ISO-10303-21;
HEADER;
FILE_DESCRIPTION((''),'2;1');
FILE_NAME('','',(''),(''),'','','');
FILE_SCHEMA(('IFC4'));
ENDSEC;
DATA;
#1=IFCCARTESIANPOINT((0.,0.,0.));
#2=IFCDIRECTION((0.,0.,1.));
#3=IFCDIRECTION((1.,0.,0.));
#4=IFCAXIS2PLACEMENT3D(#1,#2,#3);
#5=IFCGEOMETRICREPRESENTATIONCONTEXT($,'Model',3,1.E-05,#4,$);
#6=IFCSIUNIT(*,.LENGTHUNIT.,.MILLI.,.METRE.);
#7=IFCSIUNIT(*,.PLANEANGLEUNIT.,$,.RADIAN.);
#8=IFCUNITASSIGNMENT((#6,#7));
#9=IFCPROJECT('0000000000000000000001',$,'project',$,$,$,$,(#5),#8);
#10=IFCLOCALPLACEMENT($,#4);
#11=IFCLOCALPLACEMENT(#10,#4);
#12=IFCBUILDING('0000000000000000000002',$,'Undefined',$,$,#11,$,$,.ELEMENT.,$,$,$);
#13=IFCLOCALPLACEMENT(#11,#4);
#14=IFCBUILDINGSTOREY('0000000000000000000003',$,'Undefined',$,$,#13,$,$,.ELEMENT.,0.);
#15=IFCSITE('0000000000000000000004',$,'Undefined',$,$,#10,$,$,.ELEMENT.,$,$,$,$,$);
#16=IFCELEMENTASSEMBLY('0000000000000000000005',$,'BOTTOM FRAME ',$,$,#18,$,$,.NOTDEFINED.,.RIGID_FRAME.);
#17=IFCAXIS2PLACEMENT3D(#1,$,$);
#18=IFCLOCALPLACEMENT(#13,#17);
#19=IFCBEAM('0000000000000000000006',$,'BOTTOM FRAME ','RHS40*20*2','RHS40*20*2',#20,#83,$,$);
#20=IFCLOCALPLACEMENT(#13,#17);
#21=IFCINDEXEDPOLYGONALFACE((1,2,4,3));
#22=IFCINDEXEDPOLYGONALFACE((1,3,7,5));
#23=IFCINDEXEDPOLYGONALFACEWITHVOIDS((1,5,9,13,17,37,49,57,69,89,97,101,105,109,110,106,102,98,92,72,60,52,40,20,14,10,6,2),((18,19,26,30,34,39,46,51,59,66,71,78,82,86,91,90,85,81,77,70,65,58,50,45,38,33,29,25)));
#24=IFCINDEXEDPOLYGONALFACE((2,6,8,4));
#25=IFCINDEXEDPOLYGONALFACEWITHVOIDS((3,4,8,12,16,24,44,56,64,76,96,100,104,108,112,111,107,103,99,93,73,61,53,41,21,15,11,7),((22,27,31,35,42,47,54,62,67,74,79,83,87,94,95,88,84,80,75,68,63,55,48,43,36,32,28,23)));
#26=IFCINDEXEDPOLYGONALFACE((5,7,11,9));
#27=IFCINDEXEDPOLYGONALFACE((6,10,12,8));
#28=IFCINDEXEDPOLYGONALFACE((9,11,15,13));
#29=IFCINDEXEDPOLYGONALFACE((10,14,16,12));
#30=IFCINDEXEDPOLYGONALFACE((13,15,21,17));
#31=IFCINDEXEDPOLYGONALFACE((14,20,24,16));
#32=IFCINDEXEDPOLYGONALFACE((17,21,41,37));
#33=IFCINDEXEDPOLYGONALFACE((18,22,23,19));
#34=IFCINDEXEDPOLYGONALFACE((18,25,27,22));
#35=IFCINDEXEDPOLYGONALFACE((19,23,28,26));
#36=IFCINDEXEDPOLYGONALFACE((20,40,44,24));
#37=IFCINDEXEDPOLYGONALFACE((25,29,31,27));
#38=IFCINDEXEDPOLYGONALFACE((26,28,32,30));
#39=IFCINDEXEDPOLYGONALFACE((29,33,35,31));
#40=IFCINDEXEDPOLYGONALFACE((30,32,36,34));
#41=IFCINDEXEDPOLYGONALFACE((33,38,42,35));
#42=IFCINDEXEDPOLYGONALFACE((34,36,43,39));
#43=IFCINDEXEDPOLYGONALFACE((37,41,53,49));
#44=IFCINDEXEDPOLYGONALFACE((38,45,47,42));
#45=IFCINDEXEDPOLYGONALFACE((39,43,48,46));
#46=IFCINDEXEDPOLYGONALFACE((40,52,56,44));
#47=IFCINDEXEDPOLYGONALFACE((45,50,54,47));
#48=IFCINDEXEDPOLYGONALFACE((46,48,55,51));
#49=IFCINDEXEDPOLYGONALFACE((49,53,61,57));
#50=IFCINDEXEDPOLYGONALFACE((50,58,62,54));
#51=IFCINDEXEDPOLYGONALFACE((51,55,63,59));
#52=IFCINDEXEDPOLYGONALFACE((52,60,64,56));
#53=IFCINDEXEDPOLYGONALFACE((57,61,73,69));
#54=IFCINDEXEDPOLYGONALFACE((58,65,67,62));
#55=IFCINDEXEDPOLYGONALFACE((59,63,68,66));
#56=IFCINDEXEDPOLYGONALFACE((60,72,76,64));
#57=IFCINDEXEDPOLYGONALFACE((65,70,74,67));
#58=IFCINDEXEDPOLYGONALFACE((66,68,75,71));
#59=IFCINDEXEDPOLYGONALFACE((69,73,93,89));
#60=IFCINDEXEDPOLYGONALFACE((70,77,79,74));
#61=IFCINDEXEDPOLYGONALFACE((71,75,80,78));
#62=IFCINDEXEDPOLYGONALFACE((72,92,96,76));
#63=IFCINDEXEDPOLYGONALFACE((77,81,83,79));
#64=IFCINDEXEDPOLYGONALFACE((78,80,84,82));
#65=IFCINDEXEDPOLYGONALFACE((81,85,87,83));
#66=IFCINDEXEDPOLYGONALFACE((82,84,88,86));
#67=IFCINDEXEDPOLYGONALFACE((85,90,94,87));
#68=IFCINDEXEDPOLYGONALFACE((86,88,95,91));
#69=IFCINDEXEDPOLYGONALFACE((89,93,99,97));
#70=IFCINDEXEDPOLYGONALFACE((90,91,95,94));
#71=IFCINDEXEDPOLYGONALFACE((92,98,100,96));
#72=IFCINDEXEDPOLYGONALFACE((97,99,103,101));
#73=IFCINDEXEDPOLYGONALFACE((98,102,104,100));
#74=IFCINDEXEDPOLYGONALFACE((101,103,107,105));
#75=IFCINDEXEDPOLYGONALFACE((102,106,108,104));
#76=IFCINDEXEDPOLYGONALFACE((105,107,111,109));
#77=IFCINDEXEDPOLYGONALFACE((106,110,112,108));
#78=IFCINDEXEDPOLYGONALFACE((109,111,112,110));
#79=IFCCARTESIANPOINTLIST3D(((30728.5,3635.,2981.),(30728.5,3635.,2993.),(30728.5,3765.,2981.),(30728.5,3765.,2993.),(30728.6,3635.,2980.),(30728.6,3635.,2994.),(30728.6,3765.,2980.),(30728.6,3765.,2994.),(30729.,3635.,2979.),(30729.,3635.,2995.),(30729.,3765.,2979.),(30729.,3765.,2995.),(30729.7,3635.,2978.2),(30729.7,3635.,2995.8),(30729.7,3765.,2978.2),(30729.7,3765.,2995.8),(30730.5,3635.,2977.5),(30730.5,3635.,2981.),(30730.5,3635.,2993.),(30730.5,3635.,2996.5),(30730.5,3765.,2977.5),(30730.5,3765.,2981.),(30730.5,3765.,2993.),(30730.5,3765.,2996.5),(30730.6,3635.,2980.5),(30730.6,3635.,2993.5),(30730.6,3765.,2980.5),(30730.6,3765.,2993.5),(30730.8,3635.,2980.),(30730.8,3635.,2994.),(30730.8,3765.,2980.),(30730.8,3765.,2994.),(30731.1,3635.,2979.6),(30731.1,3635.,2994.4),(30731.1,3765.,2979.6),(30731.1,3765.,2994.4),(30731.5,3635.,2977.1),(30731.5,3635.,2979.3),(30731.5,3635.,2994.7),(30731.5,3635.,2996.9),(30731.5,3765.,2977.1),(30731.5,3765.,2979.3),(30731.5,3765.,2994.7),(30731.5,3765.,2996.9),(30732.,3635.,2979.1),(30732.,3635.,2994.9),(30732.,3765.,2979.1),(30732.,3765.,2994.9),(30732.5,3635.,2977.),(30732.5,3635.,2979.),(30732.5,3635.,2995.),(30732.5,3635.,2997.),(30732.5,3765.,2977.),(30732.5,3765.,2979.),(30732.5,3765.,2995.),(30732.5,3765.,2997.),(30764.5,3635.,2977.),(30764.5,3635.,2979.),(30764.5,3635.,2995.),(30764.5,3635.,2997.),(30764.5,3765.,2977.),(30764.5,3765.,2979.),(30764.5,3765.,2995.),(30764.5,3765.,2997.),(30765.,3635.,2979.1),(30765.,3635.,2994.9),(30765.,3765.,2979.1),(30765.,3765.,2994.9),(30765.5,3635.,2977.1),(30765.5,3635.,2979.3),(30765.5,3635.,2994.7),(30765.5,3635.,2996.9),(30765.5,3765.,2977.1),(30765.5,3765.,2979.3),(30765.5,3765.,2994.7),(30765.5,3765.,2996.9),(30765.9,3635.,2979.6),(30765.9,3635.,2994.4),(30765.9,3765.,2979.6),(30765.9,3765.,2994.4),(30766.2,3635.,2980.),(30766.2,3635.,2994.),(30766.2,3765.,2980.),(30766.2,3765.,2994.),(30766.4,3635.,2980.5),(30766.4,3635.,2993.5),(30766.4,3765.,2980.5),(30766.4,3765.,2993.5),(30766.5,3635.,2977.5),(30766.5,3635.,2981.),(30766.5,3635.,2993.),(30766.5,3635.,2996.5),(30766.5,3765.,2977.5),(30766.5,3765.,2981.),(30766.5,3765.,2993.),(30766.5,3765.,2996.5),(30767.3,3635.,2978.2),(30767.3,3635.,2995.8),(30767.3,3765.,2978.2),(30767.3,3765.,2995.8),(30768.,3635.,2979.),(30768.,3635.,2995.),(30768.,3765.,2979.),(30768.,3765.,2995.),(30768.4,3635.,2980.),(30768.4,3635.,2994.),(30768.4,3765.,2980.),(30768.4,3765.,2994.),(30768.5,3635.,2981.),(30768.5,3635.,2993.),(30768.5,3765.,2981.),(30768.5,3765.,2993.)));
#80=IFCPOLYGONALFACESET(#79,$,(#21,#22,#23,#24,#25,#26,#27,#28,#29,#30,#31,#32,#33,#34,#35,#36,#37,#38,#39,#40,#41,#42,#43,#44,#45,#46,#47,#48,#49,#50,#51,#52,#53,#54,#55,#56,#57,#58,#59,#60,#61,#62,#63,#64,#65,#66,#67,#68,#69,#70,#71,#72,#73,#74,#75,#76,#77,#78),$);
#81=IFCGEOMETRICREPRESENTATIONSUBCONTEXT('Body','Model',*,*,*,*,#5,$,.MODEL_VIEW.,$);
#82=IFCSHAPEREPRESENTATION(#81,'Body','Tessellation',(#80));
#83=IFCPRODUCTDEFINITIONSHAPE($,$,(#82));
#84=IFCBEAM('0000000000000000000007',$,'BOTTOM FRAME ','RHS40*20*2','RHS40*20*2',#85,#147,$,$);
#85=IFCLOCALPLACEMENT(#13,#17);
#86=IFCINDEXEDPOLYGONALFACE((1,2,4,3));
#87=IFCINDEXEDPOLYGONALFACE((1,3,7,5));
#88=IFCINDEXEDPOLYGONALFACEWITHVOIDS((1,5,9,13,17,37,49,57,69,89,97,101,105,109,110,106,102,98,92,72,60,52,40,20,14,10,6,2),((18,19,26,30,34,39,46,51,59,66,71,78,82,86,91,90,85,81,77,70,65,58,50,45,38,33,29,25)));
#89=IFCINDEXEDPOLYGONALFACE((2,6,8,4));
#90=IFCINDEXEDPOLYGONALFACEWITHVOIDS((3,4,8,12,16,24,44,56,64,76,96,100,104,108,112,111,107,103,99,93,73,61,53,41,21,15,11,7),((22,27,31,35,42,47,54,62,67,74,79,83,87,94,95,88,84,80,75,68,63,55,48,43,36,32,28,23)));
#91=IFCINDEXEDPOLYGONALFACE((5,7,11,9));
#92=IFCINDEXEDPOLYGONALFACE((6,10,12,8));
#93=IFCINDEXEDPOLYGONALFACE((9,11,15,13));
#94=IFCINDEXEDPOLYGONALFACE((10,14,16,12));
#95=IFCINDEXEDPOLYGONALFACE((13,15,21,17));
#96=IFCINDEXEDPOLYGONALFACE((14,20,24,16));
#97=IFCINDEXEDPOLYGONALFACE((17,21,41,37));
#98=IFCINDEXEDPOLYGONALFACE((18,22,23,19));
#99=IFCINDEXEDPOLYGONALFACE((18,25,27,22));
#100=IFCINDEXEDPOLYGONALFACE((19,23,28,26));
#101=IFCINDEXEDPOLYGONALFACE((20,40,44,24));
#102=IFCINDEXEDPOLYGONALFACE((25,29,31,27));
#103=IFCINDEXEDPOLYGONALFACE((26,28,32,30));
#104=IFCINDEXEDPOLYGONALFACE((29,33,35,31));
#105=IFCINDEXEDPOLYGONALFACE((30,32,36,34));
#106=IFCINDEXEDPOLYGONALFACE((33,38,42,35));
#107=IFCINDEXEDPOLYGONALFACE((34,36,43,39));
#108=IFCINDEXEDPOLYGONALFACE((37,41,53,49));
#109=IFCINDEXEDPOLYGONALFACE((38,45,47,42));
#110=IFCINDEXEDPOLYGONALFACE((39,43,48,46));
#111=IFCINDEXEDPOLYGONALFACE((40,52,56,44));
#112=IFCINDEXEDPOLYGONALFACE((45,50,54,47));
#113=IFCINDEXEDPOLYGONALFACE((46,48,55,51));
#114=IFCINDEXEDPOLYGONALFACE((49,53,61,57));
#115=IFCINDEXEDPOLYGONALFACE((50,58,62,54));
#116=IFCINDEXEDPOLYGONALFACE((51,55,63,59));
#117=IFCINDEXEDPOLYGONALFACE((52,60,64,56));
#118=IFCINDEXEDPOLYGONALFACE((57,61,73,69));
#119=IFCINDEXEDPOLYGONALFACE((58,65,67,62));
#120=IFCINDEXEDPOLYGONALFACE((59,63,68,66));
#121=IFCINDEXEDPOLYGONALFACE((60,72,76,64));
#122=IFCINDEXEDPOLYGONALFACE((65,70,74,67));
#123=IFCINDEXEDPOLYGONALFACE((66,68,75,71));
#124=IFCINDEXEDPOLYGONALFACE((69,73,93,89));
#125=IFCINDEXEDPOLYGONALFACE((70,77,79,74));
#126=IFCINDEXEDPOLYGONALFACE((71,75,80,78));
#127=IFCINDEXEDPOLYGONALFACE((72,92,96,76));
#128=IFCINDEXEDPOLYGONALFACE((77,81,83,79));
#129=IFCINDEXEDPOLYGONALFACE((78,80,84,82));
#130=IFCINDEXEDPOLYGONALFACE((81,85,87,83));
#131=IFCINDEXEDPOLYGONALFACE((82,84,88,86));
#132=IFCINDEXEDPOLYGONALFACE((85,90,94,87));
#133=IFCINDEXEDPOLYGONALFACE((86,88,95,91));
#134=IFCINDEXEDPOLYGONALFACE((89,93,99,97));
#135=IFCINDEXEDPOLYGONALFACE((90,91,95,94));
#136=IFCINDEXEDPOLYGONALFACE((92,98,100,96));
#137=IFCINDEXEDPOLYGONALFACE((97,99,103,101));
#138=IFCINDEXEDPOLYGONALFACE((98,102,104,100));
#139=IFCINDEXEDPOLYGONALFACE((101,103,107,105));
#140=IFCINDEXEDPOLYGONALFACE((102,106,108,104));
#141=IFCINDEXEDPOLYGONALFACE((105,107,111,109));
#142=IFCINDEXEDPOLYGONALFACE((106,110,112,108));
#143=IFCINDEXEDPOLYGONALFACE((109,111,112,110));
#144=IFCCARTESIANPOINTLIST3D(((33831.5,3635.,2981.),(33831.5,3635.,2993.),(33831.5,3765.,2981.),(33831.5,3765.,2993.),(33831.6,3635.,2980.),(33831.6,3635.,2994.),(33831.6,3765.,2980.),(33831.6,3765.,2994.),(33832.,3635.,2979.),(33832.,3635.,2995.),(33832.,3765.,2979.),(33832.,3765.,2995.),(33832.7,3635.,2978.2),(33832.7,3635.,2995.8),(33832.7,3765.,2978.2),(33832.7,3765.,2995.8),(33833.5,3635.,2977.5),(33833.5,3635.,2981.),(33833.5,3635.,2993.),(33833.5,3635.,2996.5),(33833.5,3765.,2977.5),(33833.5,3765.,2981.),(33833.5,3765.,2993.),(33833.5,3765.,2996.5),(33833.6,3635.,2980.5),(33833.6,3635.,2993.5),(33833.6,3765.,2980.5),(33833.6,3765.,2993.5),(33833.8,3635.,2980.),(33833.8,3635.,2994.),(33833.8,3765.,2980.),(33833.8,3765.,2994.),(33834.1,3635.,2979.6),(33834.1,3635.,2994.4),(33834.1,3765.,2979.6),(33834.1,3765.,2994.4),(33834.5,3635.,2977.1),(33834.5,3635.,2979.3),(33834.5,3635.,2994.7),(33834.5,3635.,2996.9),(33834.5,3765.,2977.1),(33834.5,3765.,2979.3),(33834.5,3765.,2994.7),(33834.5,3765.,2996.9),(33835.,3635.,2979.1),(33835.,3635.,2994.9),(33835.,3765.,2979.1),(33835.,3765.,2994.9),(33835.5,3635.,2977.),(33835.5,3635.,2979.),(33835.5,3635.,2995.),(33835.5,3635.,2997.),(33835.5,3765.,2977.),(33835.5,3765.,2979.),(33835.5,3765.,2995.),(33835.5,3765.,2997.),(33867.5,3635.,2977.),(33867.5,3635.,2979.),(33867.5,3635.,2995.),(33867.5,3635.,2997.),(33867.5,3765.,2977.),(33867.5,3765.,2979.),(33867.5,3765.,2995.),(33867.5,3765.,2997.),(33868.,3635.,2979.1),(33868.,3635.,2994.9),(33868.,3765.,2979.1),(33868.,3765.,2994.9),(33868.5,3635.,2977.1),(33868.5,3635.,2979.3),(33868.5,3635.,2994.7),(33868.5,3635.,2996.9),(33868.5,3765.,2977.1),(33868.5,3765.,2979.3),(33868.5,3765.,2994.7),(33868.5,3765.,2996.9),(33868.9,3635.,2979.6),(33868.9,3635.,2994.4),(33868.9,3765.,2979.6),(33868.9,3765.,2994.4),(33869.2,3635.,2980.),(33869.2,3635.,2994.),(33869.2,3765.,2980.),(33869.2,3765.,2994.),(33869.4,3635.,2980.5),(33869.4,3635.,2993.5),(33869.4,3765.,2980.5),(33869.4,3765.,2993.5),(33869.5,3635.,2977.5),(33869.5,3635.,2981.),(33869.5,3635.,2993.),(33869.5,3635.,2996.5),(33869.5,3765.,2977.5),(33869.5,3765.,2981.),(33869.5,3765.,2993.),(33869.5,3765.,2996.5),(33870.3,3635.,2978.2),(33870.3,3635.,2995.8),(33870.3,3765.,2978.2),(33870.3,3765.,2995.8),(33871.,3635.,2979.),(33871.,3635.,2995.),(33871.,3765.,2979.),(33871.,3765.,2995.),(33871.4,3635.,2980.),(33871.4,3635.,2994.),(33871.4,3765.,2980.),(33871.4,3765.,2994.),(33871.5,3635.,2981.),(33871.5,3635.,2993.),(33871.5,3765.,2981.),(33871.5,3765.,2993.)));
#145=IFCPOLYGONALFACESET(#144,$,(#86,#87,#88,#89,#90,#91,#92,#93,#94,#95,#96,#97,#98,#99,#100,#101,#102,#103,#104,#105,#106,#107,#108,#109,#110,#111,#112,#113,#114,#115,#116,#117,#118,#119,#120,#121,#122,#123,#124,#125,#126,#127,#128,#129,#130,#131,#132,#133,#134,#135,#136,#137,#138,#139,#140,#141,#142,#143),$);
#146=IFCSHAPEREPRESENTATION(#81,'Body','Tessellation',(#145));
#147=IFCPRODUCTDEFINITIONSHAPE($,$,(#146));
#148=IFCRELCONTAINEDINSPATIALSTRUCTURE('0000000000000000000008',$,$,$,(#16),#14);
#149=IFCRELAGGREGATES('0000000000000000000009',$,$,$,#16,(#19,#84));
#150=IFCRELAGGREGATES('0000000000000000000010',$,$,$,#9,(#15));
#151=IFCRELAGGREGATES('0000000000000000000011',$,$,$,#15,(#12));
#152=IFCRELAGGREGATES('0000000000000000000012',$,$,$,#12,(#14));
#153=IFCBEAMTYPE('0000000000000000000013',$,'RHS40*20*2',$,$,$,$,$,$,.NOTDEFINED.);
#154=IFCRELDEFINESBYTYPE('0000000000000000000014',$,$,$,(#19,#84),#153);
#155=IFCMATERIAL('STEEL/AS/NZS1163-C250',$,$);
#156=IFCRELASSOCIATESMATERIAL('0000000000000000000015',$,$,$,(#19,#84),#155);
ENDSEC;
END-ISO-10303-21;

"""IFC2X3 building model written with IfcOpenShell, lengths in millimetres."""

from ifc_helpers import new_model, si_unit, frame, origin_with_axes, origin_2d_with_axis, place, context, subcontext, project, spatial, hollow_rectangle, extrude, material, type_object, element, aggregate, save


model = new_model("IFC2X3")

# Units and contexts
model_context = context("Model", 3, precision=1e-05, world=origin_with_axes())
body_context = subcontext(model_context, "Body", "Model", "MODEL_VIEW")
ifc_project = project(units=[si_unit("LENGTHUNIT", "METRE", prefix="MILLI"), si_unit("PLANEANGLEUNIT", "RADIAN")], contexts=[model_context])

# Site, building, storey
site_placement = place(None, origin_with_axes())
site = spatial("IfcSite", under=ifc_project, at=site_placement, Name="Undefined", CompositionType="ELEMENT")
building_placement = place(site_placement, origin_with_axes())
building = spatial("IfcBuilding", under=site, at=building_placement, Name="Undefined", CompositionType="ELEMENT")
storey_placement = place(building_placement, origin_with_axes())
storey = spatial("IfcBuildingStorey", under=building, at=storey_placement, Name="Undefined", CompositionType="ELEMENT", Elevation=0.0)

# Element assembly, beams
assembly_1_placement = place(storey_placement, origin_with_axes())
assembly_1 = element("IfcElementAssembly", 1, at=assembly_1_placement, inside=storey, Name="BOTTOM FRAME ", AssemblyPlace="NOTDEFINED", PredefinedType="RIGID_FRAME")
ifc_material_1 = material(Name="STEEL/AS/NZS1163-C250")
beam_type_1 = type_object("IfcBeamType", Name="RHS40*20*2", PredefinedType="NOTDEFINED")
beam_1_placement = place(assembly_1_placement, frame((30748.5, 3765.0, 2987.0), z_axis=(1.0, 0.0, 0.0), x_axis=(0.0, -1.0, 0.0)))
beam_1 = element("IfcBeam", 2, at=beam_1_placement, type_object=beam_type_1, material=ifc_material_1, Name="BOTTOM FRAME ", Description="RHS40*20*2", ObjectType="RHS40*20*2", context=body_context, shape_type="SweptSolid", body=[
    extrude(hollow_rectangle(XDim=20.0, YDim=40.0, WallThickness=2.0, InnerFilletRadius=2.0, OuterFilletRadius=4.0, at=origin_2d_with_axis()), frame((130.0, 0.0, 0.0), z_axis=(-1.0, 0.0, 0.0), x_axis=(0.0, -1.0, 0.0)), (0.0, 0.0, 1.0), 130.0),
])
beam_2_placement = place(assembly_1_placement, frame((33851.5, 3765.0, 2987.0), z_axis=(-1.0, 0.0, 0.0), x_axis=(0.0, -1.0, 0.0)))
beam_2 = element("IfcBeam", 3, at=beam_2_placement, type_object=beam_type_1, material=ifc_material_1, Name="BOTTOM FRAME ", Description="RHS40*20*2", ObjectType="RHS40*20*2", context=body_context, shape_type="SweptSolid", body=[
    extrude(hollow_rectangle(XDim=20.0, YDim=40.0, WallThickness=2.0, InnerFilletRadius=2.0, OuterFilletRadius=4.0, at=origin_2d_with_axis()), frame((130.0, 0.0, 0.0), z_axis=(-1.0, 0.0, 0.0), x_axis=(0.0, -1.0, 0.0)), (0.0, 0.0, 1.0), 130.0),
])
aggregate(assembly_1, [beam_1, beam_2])

save(model, "model.ifc")
